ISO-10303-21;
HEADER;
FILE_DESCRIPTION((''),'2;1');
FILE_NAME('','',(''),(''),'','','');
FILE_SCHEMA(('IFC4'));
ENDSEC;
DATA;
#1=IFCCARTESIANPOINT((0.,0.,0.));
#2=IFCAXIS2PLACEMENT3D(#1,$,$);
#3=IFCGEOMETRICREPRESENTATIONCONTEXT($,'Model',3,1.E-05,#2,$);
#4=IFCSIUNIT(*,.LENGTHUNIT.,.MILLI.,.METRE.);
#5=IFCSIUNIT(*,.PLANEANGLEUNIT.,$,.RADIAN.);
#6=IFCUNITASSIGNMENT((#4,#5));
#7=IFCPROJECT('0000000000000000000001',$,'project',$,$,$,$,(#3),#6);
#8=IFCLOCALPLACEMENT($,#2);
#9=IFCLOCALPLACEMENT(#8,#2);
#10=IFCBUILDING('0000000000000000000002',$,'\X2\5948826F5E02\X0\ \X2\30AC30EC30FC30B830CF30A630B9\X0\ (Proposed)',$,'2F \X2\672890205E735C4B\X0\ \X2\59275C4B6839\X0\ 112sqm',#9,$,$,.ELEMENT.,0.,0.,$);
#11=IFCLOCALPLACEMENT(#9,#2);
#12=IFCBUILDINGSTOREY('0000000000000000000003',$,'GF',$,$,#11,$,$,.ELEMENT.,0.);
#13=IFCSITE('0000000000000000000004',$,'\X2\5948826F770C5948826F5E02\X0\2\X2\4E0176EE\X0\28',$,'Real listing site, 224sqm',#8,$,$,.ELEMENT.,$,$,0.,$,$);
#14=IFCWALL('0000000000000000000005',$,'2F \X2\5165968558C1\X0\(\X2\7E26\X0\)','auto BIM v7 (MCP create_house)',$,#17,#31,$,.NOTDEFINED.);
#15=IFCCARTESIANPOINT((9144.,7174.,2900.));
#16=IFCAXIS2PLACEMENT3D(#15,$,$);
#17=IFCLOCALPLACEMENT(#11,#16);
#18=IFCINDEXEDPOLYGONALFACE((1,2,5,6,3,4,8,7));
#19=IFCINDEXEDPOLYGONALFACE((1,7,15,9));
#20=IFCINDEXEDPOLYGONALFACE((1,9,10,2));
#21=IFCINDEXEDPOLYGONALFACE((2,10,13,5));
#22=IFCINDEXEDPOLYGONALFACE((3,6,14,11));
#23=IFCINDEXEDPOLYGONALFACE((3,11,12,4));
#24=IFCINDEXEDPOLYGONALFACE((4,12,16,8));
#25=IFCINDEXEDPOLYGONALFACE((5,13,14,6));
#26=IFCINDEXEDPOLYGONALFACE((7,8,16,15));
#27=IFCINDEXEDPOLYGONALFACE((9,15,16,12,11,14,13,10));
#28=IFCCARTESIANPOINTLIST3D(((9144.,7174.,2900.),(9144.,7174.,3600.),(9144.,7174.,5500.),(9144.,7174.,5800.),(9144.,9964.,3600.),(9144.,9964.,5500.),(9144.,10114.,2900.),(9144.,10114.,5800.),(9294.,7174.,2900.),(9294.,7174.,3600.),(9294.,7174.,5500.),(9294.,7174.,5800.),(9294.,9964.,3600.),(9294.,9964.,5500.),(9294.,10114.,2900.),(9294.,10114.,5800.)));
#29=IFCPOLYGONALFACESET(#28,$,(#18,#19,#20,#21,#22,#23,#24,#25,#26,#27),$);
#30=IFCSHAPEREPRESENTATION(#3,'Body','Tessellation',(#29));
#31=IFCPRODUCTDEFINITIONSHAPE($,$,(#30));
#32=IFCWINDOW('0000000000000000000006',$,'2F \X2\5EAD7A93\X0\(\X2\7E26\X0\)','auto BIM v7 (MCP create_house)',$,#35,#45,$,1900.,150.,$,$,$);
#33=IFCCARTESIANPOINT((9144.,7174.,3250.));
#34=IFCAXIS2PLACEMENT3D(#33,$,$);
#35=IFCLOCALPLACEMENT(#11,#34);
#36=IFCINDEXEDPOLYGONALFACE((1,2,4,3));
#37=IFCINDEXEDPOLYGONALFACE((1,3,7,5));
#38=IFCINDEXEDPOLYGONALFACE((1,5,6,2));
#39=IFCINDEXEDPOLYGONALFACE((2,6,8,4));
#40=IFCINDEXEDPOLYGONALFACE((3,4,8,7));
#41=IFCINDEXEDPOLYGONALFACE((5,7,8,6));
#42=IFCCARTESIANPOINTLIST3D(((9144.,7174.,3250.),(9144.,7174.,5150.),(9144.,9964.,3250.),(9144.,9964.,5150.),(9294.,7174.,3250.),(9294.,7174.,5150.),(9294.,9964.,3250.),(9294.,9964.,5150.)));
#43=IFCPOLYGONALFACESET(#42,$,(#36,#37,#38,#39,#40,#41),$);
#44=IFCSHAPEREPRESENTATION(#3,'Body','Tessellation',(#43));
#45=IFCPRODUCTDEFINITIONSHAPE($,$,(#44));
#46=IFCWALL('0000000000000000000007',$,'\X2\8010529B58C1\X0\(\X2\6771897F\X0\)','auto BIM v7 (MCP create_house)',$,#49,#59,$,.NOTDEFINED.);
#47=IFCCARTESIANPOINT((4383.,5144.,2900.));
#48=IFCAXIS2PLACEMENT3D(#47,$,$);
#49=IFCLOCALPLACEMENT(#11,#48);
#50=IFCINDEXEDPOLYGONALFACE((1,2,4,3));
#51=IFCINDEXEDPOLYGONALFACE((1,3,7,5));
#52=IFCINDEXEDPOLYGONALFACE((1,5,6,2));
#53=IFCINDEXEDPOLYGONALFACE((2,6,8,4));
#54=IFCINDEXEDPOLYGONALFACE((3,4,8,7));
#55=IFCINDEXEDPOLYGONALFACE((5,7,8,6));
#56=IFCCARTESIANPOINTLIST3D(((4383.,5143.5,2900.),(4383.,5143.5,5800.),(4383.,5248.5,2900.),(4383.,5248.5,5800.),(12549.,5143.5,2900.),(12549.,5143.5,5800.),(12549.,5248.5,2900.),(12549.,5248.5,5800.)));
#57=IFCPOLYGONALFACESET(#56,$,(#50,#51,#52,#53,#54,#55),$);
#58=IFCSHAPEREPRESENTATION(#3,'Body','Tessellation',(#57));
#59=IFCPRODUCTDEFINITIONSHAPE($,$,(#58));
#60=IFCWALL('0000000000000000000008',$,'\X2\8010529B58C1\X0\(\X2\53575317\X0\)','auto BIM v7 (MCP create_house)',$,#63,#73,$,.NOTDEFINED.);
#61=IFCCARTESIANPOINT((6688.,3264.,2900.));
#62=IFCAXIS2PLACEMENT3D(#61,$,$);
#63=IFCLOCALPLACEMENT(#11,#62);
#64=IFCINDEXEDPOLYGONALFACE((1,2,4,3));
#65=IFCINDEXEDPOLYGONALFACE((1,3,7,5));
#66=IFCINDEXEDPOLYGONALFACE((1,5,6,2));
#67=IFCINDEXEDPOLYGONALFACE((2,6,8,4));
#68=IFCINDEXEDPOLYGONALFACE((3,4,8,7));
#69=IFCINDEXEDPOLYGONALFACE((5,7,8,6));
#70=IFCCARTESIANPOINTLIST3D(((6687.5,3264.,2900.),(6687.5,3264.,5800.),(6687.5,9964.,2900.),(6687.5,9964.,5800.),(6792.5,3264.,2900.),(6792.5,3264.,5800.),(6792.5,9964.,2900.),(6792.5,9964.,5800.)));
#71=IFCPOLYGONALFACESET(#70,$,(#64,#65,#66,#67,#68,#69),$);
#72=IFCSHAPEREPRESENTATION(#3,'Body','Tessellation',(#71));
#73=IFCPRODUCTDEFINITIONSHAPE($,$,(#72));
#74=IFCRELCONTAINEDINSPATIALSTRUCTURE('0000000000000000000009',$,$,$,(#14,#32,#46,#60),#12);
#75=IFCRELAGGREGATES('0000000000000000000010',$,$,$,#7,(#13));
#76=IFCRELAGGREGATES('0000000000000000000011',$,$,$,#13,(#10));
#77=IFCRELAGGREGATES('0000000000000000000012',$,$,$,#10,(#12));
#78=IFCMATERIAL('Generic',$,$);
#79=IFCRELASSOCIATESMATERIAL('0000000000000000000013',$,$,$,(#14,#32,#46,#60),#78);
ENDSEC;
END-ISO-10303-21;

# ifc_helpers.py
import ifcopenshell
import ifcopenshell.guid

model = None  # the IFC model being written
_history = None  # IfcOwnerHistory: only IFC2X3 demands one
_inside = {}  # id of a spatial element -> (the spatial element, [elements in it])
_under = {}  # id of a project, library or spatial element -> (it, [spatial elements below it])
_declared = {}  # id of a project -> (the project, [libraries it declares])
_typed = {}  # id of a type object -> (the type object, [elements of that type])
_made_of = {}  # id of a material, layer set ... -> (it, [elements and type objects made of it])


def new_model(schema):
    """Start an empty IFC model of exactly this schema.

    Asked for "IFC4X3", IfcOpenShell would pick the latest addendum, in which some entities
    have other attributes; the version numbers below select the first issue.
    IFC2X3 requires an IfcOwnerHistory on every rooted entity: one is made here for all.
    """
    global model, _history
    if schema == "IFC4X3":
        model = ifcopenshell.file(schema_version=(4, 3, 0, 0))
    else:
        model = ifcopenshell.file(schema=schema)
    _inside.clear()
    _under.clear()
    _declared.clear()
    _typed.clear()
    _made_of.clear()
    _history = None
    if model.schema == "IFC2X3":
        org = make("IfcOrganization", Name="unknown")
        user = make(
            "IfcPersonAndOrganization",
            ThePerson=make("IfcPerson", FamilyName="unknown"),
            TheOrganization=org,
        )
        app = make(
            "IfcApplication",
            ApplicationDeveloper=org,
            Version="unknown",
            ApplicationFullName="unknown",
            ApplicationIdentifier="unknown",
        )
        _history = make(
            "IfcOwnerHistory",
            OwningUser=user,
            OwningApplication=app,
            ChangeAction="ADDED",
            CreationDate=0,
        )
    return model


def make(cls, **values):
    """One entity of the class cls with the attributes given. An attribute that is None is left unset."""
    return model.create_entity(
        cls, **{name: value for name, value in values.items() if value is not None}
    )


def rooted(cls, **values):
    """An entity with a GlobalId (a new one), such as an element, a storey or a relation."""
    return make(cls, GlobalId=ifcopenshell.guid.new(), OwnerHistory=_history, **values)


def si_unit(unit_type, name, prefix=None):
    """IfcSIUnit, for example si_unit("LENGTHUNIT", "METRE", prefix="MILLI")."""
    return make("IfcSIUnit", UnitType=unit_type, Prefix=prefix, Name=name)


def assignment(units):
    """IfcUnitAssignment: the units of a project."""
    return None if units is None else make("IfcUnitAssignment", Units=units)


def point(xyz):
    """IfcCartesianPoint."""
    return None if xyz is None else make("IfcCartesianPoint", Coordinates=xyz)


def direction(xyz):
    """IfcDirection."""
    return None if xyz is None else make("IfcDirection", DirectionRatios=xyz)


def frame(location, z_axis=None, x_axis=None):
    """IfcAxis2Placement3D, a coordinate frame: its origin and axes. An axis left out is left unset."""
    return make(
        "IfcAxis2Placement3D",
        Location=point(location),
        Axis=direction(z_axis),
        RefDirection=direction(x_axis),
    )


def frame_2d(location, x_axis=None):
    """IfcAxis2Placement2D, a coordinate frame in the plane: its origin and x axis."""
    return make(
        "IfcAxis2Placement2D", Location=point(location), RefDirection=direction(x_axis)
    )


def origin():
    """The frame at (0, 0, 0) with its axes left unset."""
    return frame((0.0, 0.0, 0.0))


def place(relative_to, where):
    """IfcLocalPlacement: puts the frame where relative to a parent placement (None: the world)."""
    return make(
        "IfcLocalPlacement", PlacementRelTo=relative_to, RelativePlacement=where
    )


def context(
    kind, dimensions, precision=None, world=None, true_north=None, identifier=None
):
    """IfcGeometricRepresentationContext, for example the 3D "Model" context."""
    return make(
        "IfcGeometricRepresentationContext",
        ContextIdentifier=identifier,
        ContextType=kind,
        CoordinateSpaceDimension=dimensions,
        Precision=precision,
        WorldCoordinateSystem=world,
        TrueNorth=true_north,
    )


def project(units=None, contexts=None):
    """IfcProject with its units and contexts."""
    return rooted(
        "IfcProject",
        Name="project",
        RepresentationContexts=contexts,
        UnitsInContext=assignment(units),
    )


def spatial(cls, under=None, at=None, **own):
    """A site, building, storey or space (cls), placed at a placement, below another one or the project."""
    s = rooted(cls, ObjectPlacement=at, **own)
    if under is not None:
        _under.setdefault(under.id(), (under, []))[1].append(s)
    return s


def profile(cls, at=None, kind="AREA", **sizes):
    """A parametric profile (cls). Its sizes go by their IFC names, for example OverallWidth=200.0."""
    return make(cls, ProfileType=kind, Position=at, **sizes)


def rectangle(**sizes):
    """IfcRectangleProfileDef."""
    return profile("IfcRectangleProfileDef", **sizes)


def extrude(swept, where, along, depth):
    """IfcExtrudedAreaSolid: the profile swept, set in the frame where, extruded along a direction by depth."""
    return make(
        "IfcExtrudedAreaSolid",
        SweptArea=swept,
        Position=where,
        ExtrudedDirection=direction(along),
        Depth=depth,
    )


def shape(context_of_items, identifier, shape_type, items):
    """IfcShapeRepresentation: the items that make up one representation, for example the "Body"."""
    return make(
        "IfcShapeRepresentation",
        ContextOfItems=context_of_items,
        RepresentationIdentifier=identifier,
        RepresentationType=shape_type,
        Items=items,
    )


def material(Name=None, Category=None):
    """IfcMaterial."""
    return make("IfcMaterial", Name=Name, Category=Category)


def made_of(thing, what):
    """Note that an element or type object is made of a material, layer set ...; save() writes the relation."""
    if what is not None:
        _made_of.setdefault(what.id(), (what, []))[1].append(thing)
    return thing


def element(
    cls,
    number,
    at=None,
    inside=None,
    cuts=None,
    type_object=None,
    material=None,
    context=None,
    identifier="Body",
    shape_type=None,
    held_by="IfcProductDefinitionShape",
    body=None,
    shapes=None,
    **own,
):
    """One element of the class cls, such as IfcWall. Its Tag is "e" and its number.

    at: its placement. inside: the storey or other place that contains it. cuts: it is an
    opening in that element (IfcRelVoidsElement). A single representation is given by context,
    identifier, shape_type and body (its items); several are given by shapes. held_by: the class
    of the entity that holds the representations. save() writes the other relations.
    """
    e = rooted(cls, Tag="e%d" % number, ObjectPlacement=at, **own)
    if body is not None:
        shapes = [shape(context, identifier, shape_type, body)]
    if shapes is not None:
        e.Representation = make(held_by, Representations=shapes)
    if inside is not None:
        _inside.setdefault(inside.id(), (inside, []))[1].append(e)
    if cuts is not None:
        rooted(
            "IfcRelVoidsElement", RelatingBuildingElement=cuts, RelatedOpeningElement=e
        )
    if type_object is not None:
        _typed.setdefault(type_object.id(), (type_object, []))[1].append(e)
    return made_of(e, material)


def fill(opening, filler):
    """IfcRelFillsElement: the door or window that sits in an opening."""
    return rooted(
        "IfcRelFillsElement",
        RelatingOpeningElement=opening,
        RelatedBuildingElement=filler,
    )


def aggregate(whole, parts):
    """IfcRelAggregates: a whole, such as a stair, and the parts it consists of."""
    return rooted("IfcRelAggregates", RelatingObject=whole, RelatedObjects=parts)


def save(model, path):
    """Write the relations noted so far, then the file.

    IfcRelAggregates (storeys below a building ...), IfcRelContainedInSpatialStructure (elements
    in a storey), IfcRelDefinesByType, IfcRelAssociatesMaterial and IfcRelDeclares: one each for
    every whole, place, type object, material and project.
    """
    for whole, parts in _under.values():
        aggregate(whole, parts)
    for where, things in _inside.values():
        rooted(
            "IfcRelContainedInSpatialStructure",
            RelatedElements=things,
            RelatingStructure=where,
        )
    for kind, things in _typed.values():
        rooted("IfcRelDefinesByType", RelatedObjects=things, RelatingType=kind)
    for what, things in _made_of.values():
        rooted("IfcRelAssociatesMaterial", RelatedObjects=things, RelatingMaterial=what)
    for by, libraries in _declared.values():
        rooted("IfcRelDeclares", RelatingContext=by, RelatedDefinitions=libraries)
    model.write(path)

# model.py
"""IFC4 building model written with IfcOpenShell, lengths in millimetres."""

from ifc_helpers import new_model, si_unit, frame, frame_2d, origin, place, context, project, spatial, rectangle, extrude, material, element, fill, save


model = new_model("IFC4")

# Units and contexts
model_context = context("Model", 3, precision=1e-05, world=origin())
ifc_project = project(units=[si_unit("LENGTHUNIT", "METRE", prefix="MILLI"), si_unit("PLANEANGLEUNIT", "RADIAN")], contexts=[model_context])

# Site, building, storey
site_placement = place(None, origin())
site = spatial("IfcSite", under=ifc_project, at=site_placement, Name="奈良県奈良市2丁目28", ObjectType="Real listing site, 224sqm", CompositionType="ELEMENT", RefElevation=0.0)
building_placement = place(site_placement, origin())
building = spatial("IfcBuilding", under=site, at=building_placement, Name="奈良市 ガレージハウス (Proposed)", ObjectType="2F 木造平屋 大屋根 112sqm", CompositionType="ELEMENT", ElevationOfRefHeight=0.0, ElevationOfTerrain=0.0)
storey_placement = place(building_placement, origin())
storey = spatial("IfcBuildingStorey", under=building, at=storey_placement, Name="GF", CompositionType="ELEMENT", Elevation=0.0)

# Shared definitions
ifc_material = material(Name="Generic")

# Wall, opening, window
wall_1_placement = place(storey_placement, frame((9144.0, 7174.0, 2900.0)))
wall_1 = element("IfcWall", 1, at=wall_1_placement, inside=storey, material=ifc_material, Name="2F 入隅壁(縦)", Description="auto BIM v7 (MCP create_house)", PredefinedType="NOTDEFINED", context=model_context, shape_type="SweptSolid", body=[
    extrude(rectangle(XDim=150.0, YDim=2940.0, at=frame_2d((75.0, 1470.0))), frame((9144.0, 7174.0, 2900.0)), (0.0, 0.0, 1.0), 2900.0),
])
opening_1_placement = place(storey_placement, frame((9144.0, 7174.0, 3250.0)))
opening_1 = element("IfcOpeningElement", 2, at=opening_1_placement, cuts=wall_1, PredefinedType="NOTDEFINED", context=model_context, shape_type="SweptSolid", body=[
    extrude(rectangle(XDim=150.0, YDim=2790.0, at=frame_2d((75.0, 1395.0))), frame((9144.0, 7174.0, 3250.0)), (0.0, 0.0, 1.0), 1900.0),
])
window_1_placement = place(storey_placement, frame((9144.0, 7174.0, 3250.0)))
window_1 = element("IfcWindow", 3, at=window_1_placement, inside=storey, material=ifc_material, Name="2F 庭窓(縦)", Description="auto BIM v7 (MCP create_house)", OverallHeight=1900.0, OverallWidth=150.0, context=model_context, shape_type="SweptSolid", body=[
    extrude(rectangle(XDim=150.0, YDim=2790.0, at=frame_2d((75.0, 1395.0))), frame((9144.0, 7174.0, 3250.0)), (0.0, 0.0, 1.0), 1900.0),
])
fill(opening_1, window_1)

# Walls
wall_2_placement = place(storey_placement, frame((4383.0, 5144.0, 2900.0)))
element("IfcWall", 4, at=wall_2_placement, inside=storey, material=ifc_material, Name="耐力壁(東西)", Description="auto BIM v7 (MCP create_house)", PredefinedType="NOTDEFINED", context=model_context, shape_type="SweptSolid", body=[
    extrude(rectangle(XDim=8166.0, YDim=105.0, at=frame_2d((4083.0, 52.0))), frame((4383.0, 5144.0, 2900.0)), (0.0, 0.0, 1.0), 2900.0),
])
wall_3_placement = place(storey_placement, frame((6688.0, 3264.0, 2900.0)))
element("IfcWall", 5, at=wall_3_placement, inside=storey, material=ifc_material, Name="耐力壁(南北)", Description="auto BIM v7 (MCP create_house)", PredefinedType="NOTDEFINED", context=model_context, shape_type="SweptSolid", body=[
    extrude(rectangle(XDim=105.0, YDim=6700.0, at=frame_2d((52.0, 3350.0))), frame((6688.0, 3264.0, 2900.0)), (0.0, 0.0, 1.0), 2900.0),
])

save(model, "model.ifc")
